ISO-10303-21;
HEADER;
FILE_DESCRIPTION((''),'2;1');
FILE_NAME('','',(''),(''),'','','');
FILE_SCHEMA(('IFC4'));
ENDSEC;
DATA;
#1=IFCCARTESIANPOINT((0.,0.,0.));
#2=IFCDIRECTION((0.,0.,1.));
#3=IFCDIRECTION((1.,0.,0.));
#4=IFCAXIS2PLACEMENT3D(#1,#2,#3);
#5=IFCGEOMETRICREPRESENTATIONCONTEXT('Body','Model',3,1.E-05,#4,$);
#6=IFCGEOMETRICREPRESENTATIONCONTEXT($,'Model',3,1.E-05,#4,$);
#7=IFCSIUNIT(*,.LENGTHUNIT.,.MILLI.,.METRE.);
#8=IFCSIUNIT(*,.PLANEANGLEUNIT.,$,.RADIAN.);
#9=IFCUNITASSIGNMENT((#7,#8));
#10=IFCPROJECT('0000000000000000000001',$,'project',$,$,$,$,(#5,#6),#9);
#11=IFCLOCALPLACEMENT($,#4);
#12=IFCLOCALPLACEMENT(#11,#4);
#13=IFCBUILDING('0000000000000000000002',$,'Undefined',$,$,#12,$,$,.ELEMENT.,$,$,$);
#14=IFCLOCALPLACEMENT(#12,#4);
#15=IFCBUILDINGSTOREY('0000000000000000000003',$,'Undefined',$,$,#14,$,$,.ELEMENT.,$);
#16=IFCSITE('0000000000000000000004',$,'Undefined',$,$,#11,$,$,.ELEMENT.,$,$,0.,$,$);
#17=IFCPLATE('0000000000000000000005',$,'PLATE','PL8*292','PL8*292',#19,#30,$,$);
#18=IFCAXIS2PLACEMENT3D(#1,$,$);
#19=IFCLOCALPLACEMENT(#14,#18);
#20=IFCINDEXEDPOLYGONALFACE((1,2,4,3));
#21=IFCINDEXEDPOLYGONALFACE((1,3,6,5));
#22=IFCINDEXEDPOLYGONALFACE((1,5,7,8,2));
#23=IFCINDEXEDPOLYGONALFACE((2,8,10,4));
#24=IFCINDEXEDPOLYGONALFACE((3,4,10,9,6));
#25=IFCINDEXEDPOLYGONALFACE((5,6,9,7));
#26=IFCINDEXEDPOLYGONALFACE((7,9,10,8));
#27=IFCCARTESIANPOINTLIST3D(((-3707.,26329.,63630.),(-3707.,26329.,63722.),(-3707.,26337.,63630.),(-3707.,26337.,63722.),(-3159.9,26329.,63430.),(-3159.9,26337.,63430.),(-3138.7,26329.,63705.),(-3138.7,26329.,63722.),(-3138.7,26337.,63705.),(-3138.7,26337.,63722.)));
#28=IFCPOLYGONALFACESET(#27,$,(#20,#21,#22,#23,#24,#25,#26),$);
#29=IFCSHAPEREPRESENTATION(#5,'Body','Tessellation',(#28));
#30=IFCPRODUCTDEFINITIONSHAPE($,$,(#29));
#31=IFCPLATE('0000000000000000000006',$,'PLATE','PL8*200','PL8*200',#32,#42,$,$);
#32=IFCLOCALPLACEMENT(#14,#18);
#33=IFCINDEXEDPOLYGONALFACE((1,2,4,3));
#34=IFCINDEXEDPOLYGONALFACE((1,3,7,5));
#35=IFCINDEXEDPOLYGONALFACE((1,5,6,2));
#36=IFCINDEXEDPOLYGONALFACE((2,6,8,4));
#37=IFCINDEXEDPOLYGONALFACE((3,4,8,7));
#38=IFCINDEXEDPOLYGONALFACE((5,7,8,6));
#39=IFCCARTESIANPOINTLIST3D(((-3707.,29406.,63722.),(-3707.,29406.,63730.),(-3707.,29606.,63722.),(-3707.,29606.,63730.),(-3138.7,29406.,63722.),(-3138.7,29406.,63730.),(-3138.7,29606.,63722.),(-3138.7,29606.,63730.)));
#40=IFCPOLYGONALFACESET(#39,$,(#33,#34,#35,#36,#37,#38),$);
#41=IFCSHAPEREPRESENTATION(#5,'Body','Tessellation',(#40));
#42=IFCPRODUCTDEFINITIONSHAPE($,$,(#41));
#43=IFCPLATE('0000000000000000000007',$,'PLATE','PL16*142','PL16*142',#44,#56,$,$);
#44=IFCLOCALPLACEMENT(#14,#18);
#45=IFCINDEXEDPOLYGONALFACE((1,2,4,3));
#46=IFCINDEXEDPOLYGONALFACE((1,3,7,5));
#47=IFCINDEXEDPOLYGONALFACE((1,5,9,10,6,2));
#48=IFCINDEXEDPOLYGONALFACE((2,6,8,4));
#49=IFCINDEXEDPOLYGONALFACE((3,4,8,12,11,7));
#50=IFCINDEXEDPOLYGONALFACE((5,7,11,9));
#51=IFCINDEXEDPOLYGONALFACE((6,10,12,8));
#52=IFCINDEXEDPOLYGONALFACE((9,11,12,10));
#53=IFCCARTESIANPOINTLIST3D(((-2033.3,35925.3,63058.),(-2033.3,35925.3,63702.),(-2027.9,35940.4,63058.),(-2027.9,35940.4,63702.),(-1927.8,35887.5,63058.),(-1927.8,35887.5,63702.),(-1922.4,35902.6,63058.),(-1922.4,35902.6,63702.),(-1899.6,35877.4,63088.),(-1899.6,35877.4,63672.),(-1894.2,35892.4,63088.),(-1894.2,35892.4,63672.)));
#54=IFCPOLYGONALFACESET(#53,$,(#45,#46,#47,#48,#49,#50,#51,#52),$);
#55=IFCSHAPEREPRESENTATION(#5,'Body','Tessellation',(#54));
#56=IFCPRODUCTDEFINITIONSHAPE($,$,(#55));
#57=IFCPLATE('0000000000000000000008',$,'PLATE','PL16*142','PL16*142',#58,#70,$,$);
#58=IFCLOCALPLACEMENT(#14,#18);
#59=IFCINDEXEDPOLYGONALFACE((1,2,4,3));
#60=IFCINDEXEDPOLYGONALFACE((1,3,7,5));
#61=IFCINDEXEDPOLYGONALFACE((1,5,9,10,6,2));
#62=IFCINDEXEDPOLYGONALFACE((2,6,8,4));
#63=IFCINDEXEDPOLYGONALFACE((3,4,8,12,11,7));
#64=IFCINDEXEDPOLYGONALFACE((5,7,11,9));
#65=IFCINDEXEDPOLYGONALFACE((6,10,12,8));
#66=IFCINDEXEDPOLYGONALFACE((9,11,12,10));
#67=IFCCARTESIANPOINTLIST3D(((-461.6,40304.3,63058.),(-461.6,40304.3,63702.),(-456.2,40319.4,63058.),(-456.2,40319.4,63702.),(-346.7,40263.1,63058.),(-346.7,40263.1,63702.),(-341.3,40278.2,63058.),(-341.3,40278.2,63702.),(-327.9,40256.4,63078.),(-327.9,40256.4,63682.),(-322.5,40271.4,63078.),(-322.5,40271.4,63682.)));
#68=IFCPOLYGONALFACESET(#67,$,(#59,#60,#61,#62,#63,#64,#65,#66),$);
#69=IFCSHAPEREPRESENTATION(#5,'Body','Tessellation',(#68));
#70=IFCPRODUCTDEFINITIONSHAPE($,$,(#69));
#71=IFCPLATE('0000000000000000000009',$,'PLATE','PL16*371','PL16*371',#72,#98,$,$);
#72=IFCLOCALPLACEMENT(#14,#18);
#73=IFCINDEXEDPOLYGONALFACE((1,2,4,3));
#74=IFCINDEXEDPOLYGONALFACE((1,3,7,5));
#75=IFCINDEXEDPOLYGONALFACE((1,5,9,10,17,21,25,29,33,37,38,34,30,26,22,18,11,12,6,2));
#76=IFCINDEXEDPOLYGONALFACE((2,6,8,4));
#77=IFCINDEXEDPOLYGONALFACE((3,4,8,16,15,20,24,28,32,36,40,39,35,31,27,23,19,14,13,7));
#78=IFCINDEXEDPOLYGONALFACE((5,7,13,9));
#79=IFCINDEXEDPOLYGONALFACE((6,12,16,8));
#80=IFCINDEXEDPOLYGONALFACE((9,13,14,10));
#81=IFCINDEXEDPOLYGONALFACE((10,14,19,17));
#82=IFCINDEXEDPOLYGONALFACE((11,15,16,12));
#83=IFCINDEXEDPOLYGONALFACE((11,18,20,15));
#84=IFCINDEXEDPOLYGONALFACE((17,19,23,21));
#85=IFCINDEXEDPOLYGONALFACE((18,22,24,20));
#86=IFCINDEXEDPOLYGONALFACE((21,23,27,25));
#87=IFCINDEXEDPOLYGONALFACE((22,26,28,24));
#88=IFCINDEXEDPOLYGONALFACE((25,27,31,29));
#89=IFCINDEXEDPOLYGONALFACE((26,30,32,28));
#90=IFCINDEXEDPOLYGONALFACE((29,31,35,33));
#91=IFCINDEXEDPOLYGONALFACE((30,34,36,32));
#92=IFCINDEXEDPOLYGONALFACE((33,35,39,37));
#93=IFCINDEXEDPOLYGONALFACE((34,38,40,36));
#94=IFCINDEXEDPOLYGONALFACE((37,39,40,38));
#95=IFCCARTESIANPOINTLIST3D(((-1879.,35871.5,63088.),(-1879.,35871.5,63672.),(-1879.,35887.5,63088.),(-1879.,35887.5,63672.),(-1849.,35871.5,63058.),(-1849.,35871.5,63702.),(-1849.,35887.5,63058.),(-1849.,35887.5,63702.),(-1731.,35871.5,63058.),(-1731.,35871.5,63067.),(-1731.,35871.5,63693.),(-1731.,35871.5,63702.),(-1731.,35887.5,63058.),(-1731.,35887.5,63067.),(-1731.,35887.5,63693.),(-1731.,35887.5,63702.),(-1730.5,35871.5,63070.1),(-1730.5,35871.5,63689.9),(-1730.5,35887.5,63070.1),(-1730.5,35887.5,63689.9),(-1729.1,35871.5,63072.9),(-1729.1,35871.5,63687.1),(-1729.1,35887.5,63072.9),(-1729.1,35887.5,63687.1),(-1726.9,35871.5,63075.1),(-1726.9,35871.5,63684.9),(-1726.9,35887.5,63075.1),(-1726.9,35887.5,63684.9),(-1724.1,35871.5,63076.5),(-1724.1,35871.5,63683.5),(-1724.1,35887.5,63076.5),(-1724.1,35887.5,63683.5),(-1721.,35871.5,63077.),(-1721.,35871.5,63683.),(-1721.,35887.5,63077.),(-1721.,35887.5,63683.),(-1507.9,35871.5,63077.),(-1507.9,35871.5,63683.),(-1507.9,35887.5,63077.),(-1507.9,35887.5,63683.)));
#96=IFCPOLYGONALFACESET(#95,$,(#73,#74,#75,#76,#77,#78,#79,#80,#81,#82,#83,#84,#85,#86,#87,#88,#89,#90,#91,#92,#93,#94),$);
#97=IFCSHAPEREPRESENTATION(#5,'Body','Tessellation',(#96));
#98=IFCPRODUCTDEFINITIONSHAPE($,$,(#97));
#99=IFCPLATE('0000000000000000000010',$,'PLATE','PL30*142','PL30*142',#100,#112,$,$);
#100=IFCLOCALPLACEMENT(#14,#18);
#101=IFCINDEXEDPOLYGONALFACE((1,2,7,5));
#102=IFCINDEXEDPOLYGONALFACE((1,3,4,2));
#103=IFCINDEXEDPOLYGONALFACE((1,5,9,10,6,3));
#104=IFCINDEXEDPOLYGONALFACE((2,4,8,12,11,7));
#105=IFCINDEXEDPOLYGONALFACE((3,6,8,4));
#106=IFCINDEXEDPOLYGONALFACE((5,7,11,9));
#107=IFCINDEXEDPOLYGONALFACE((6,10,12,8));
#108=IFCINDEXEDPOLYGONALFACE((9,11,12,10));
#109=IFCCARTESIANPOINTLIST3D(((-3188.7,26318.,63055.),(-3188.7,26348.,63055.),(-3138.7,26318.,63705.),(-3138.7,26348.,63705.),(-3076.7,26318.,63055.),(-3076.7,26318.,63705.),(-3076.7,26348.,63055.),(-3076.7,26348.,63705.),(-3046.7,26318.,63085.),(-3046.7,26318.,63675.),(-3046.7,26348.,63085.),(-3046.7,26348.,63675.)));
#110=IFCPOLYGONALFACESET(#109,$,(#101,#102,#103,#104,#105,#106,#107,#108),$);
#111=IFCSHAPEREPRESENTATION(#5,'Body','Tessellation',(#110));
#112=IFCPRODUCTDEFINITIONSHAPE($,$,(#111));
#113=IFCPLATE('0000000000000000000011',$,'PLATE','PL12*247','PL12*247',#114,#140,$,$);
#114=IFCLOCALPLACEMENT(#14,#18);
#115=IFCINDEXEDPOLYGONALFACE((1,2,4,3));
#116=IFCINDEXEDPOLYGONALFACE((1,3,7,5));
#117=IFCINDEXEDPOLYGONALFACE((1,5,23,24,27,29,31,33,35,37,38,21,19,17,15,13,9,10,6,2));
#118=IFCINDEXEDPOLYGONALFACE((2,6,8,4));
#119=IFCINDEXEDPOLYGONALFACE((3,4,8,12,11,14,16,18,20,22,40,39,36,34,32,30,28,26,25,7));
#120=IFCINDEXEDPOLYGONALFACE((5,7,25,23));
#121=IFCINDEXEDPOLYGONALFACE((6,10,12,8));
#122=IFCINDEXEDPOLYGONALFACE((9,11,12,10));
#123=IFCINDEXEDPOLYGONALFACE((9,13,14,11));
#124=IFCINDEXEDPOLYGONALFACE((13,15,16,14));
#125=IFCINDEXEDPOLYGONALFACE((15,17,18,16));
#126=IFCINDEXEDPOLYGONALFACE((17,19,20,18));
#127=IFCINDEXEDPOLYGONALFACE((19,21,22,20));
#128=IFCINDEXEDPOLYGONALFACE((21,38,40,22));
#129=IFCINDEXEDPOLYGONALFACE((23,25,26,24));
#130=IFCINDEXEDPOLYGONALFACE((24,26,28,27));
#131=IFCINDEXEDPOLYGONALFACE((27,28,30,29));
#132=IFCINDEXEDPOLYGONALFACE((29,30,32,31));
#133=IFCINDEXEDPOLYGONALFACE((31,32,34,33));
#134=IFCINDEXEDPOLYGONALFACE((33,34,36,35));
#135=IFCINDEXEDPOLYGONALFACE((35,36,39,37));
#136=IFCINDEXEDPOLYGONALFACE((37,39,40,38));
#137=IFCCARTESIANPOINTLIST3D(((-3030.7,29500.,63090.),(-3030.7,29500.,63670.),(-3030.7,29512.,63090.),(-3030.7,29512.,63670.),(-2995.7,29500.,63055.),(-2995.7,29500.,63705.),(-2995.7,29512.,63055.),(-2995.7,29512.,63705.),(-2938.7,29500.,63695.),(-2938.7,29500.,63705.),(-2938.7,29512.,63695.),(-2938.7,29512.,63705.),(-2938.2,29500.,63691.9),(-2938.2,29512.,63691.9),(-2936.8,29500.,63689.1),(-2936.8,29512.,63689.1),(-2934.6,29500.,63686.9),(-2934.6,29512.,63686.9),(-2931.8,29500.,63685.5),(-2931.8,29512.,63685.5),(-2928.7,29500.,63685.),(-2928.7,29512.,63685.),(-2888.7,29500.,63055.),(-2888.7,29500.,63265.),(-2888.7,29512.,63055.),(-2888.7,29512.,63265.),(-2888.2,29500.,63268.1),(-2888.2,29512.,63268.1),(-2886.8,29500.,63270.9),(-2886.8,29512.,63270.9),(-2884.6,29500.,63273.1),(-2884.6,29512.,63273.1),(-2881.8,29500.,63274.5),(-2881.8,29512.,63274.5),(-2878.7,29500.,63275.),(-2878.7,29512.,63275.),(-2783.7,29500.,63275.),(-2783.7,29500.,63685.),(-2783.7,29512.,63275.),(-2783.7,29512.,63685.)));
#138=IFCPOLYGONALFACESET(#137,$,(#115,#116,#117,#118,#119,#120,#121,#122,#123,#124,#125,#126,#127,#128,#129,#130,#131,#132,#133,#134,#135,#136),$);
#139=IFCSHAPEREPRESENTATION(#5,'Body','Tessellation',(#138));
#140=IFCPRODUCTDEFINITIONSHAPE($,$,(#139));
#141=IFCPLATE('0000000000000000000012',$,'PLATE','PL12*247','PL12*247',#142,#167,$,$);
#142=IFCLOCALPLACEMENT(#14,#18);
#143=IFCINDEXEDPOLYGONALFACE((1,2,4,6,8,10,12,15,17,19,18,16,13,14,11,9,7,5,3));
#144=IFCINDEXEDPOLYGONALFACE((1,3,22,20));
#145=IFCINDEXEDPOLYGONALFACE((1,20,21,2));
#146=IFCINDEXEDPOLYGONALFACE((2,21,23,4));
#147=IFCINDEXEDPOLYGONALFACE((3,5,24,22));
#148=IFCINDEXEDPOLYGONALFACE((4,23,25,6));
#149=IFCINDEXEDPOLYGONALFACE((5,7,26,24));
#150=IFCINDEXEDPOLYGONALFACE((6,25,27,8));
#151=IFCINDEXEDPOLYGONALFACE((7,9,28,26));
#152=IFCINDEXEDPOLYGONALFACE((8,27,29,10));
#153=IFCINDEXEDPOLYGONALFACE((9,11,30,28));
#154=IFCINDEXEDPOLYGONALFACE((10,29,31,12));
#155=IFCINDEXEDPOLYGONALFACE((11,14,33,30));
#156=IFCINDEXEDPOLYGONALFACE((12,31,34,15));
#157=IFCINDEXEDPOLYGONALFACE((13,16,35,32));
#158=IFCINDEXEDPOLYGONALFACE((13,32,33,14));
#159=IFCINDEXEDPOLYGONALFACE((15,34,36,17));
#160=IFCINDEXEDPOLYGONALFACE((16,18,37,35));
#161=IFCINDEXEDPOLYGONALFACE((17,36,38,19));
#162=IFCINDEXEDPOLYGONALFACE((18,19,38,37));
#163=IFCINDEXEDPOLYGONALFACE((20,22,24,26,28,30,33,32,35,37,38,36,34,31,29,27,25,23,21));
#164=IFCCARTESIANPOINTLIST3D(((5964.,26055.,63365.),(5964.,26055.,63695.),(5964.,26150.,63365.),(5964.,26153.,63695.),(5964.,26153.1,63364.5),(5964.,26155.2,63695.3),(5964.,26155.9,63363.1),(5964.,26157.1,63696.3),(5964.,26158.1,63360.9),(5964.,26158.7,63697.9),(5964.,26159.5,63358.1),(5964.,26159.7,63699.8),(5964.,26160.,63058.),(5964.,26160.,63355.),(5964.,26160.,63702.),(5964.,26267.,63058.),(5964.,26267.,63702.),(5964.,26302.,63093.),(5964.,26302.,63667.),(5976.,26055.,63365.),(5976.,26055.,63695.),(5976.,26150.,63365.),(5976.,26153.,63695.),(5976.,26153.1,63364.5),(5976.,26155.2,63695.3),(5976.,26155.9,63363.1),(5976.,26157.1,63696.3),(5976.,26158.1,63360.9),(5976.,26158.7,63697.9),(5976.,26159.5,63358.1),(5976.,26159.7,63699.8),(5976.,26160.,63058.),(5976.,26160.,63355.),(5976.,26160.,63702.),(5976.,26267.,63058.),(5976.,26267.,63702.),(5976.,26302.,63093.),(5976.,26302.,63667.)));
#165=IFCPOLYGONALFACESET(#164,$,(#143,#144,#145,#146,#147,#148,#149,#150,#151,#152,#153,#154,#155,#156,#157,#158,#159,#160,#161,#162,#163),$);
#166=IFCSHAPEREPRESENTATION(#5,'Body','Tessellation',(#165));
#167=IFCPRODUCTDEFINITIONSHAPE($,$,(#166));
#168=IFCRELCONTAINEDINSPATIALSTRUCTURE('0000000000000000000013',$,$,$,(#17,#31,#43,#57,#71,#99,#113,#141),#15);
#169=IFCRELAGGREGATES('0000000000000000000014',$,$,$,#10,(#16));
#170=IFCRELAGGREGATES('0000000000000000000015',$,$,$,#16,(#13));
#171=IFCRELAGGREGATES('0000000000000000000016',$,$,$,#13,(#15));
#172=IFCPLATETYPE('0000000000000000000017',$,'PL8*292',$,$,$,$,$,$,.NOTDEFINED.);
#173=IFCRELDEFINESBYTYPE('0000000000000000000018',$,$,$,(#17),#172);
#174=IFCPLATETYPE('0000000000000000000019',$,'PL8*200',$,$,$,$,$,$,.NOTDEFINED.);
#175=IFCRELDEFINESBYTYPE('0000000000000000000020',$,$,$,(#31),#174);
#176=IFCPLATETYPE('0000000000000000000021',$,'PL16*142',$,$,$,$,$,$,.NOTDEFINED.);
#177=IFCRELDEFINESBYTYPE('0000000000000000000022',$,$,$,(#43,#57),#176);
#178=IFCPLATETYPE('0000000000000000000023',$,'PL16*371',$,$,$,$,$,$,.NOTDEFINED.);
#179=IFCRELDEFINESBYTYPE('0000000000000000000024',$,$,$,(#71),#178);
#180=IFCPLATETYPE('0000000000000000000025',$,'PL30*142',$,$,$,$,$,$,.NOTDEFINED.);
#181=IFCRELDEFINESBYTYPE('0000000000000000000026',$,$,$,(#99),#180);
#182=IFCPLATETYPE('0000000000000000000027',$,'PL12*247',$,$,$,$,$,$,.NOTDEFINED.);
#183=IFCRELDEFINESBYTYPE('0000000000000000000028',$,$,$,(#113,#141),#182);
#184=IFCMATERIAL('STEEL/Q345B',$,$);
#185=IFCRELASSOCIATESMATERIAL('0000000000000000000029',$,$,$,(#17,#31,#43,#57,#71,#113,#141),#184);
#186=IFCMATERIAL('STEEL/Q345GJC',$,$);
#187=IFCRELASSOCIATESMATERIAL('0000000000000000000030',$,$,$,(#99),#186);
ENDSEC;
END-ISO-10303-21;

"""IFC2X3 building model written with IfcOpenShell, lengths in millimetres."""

from ifc_helpers import new_model, si_unit, frame, origin_with_axes, place, context, project, spatial, polyline, outline, extrude, material, type_object, element, save


model = new_model("IFC2X3")

# Units and contexts
model_context_1 = context("Model", 3, precision=1e-05, world=origin_with_axes(), identifier="Body")
model_context_2 = context("Model", 3, precision=1e-05, world=origin_with_axes())
ifc_project = project(units=[si_unit("LENGTHUNIT", "METRE", prefix="MILLI"), si_unit("PLANEANGLEUNIT", "RADIAN")], contexts=[model_context_1, model_context_2])

# Site, building, storey
site_placement = place(None, origin_with_axes())
site = spatial("IfcSite", under=ifc_project, at=site_placement, Name="Undefined", CompositionType="ELEMENT", RefElevation=0.0)
building_placement = place(site_placement, origin_with_axes())
building = spatial("IfcBuilding", under=site, at=building_placement, Name="Undefined", CompositionType="ELEMENT")
storey_placement = place(building_placement, origin_with_axes())
storey = spatial("IfcBuildingStorey", under=building, at=storey_placement, Name="Undefined", CompositionType="ELEMENT")

# Shared definitions
ifc_material_1 = material(Name="STEEL/Q345B")

# Shared definitions
ifc_material_2 = material(Name="STEEL/Q345GJC")

# Plates
plate_type_1 = type_object("IfcPlateType", Name="PL8*292", PredefinedType="NOTDEFINED")
for number, where, z_axis, x_axis, name in (
    (1, (-3138.7, 26333.0, 63722.0), (0.0, 1.0, 0.0), (0.0, 0.0, -1.0), "PLATE"),
):
    element("IfcPlate", number, at=place(storey_placement, frame(where, z_axis=z_axis, x_axis=x_axis)), inside=storey, type_object=plate_type_1, material=ifc_material_1, Name=name, Description="PL8*292", ObjectType="PL8*292", context=model_context_1, shape_type="SweptSolid", body=[
        extrude(outline(polyline([(0.0, 0.0), (17.0, 0.0), (292.0, 21.2), (92.0, 568.3), (0.0, 568.3), (0.0, 0.0)])), frame((0.0, 0.0, -4.0), z_axis=(0.0, 0.0, 1.0), x_axis=(1.0, 0.0, 0.0)), (0.0, 0.0, 1.0), 8.0),
    ])
plate_type_2 = type_object("IfcPlateType", Name="PL8*200", PredefinedType="NOTDEFINED")
plate_1_placement = place(storey_placement, frame((-3707.0, 29406.0, 63726.0), z_axis=(0.0, 0.0, 1.0), x_axis=(1.0, 0.0, 0.0)))
element("IfcPlate", 2, at=plate_1_placement, inside=storey, type_object=plate_type_2, material=ifc_material_1, Name="PLATE", Description="PL8*200", ObjectType="PL8*200", context=model_context_1, shape_type="SweptSolid", body=[
    extrude(outline(polyline([(0.0, 0.0), (568.3, 0.0), (568.3, 200.0), (0.0, 200.0), (0.0, 0.0)])), frame((0.0, 0.0, -4.0), z_axis=(0.0, 0.0, 1.0), x_axis=(1.0, 0.0, 0.0)), (0.0, 0.0, 1.0), 8.0),
])
plate_type_3 = type_object("IfcPlateType", Name="PL16*142", PredefinedType="NOTDEFINED")
plate_2_placement = place(storey_placement, frame((-1896.9, 35884.9, 63058.0), z_axis=(0.337816, 0.941212, 0.0), x_axis=(-0.941212, 0.337816, 0.0)))
element("IfcPlate", 3, at=plate_2_placement, inside=storey, type_object=plate_type_3, material=ifc_material_1, Name="PLATE", Description="PL16*142", ObjectType="PL16*142", context=model_context_1, shape_type="SweptSolid", body=[
    extrude(outline(polyline([(0.0, 30.0), (30.0, 0.0), (142.0, 0.0), (142.0, 644.0), (30.0, 644.0), (0.0, 614.0), (0.0, 30.0)])), frame((0.0, 0.0, -8.0), z_axis=(0.0, 0.0, 1.0), x_axis=(1.0, 0.0, 0.0)), (0.0, 0.0, 1.0), 16.0),
])
plate_3_placement = place(storey_placement, frame((-325.2, 40263.9, 63058.0), z_axis=(0.337816, 0.941212, 0.0), x_axis=(-0.941212, 0.337816, 0.0)))
element("IfcPlate", 4, at=plate_3_placement, inside=storey, type_object=plate_type_3, material=ifc_material_1, Name="PLATE", Description="PL16*142", ObjectType="PL16*142", context=model_context_1, shape_type="SweptSolid", body=[
    extrude(outline(polyline([(0.0, 20.0), (20.0, 0.0), (142.0, 0.0), (142.0, 644.0), (20.0, 644.0), (0.0, 624.0), (0.0, 20.0)])), frame((0.0, 0.0, -8.0), z_axis=(0.0, 0.0, 1.0), x_axis=(1.0, 0.0, 0.0)), (0.0, 0.0, 1.0), 16.0),
])
plate_type_4 = type_object("IfcPlateType", Name="PL16*371", PredefinedType="NOTDEFINED")
plate_4_placement = place(storey_placement, frame((-1879.0, 35879.5, 63088.0), z_axis=(0.0, -1.0, 0.0), x_axis=(0.707107, 0.0, -0.707107)))
element("IfcPlate", 5, at=plate_4_placement, inside=storey, type_object=plate_type_4, material=ifc_material_1, Name="PLATE", Description="PL16*371", ObjectType="PL16*371", context=model_context_1, shape_type="SweptSolid", body=[
    extrude(outline(polyline([(0.0, 0.0), (42.4, 0.0), (125.9, 83.4), (119.5, 89.8), (117.7, 92.3), (116.7, 95.3), (116.7, 98.4), (117.7, 101.4), (119.5, 103.9), (270.2, 254.6), (-158.3, 683.1), (-309.0, 532.4), (-311.5, 530.6), (-314.5, 529.6), (-317.6, 529.6), (-320.6, 530.6), (-323.1, 532.4), (-329.5, 538.8), (-413.0, 455.4), (-413.0, 413.0), (0.0, 0.0)])), frame((0.0, 0.0, -8.0), z_axis=(0.0, 0.0, 1.0), x_axis=(1.0, 0.0, 0.0)), (0.0, 0.0, 1.0), 16.0),
])
plate_type_5 = type_object("IfcPlateType", Name="PL30*142", PredefinedType="NOTDEFINED")
plate_5_placement = place(storey_placement, frame((-3046.7, 26333.0, 63055.0), z_axis=(0.0, 1.0, 0.0), x_axis=(-1.0, 0.0, 0.0)))
element("IfcPlate", 6, at=plate_5_placement, inside=storey, type_object=plate_type_5, material=ifc_material_2, Name="PLATE", Description="PL30*142", ObjectType="PL30*142", context=model_context_1, shape_type="SweptSolid", body=[
    extrude(outline(polyline([(0.0, 30.0), (30.0, 0.0), (142.0, 0.0), (92.0, 650.0), (30.0, 650.0), (0.0, 620.0), (0.0, 30.0)])), frame((0.0, 0.0, -15.0), z_axis=(0.0, 0.0, 1.0), x_axis=(1.0, 0.0, 0.0)), (0.0, 0.0, 1.0), 30.0),
])
plate_type_6 = type_object("IfcPlateType", Name="PL12*247", PredefinedType="NOTDEFINED")
plate_6_placement = place(storey_placement, frame((-3030.7, 29506.0, 63090.0), z_axis=(0.0, -1.0, 0.0), x_axis=(0.707107, 0.0, -0.707107)))
element("IfcPlate", 7, at=plate_6_placement, inside=storey, type_object=plate_type_6, material=ifc_material_1, Name="PLATE", Description="PL12*247", ObjectType="PL12*247", context=model_context_1, shape_type="SweptSolid", body=[
    extrude(outline(polyline([(0.0, 0.0), (49.5, 0.0), (125.2, 75.7), (-23.3, 224.2), (-25.2, 226.7), (-26.1, 229.7), (-26.1, 232.8), (-25.2, 235.8), (-23.3, 238.3), (43.8, 305.5), (-246.1, 595.4), (-348.6, 492.9), (-351.1, 491.0), (-354.1, 490.0), (-357.2, 490.0), (-360.2, 491.0), (-362.7, 492.9), (-369.8, 499.9), (-410.1, 459.6), (-410.1, 410.1), (0.0, 0.0)])), frame((0.0, 0.0, -6.0), z_axis=(0.0, 0.0, 1.0), x_axis=(1.0, 0.0, 0.0)), (0.0, 0.0, 1.0), 12.0),
])
for number, where, z_axis, x_axis, name in (
    (8, (5970.0, 26302.0, 63093.0), (-1.0, 0.0, 0.0), (0.0, -0.707107, -0.707107), "PLATE"),
):
    element("IfcPlate", number, at=place(storey_placement, frame(where, z_axis=z_axis, x_axis=x_axis)), inside=storey, type_object=plate_type_6, material=ifc_material_1, Name=name, Description="PL12*247", ObjectType="PL12*247", context=model_context_1, shape_type="SweptSolid", body=[
        extrude(outline(polyline([(0.0, 0.0), (49.5, 0.0), (125.2, 75.7), (-84.9, 285.7), (-86.7, 288.2), (-87.7, 291.2), (-87.7, 294.3), (-86.7, 297.3), (-84.9, 299.8), (-17.7, 367.0), (-251.0, 600.3), (-320.3, 531.0), (-322.1, 529.7), (-324.2, 529.1), (-326.4, 529.1), (-328.4, 529.7), (-330.2, 531.0), (-405.9, 455.4), (-405.9, 405.9), (0.0, 0.0)])), frame((0.0, 0.0, -6.0), z_axis=(0.0, 0.0, 1.0), x_axis=(1.0, 0.0, 0.0)), (0.0, 0.0, 1.0), 12.0),
    ])

save(model, "model.ifc")
